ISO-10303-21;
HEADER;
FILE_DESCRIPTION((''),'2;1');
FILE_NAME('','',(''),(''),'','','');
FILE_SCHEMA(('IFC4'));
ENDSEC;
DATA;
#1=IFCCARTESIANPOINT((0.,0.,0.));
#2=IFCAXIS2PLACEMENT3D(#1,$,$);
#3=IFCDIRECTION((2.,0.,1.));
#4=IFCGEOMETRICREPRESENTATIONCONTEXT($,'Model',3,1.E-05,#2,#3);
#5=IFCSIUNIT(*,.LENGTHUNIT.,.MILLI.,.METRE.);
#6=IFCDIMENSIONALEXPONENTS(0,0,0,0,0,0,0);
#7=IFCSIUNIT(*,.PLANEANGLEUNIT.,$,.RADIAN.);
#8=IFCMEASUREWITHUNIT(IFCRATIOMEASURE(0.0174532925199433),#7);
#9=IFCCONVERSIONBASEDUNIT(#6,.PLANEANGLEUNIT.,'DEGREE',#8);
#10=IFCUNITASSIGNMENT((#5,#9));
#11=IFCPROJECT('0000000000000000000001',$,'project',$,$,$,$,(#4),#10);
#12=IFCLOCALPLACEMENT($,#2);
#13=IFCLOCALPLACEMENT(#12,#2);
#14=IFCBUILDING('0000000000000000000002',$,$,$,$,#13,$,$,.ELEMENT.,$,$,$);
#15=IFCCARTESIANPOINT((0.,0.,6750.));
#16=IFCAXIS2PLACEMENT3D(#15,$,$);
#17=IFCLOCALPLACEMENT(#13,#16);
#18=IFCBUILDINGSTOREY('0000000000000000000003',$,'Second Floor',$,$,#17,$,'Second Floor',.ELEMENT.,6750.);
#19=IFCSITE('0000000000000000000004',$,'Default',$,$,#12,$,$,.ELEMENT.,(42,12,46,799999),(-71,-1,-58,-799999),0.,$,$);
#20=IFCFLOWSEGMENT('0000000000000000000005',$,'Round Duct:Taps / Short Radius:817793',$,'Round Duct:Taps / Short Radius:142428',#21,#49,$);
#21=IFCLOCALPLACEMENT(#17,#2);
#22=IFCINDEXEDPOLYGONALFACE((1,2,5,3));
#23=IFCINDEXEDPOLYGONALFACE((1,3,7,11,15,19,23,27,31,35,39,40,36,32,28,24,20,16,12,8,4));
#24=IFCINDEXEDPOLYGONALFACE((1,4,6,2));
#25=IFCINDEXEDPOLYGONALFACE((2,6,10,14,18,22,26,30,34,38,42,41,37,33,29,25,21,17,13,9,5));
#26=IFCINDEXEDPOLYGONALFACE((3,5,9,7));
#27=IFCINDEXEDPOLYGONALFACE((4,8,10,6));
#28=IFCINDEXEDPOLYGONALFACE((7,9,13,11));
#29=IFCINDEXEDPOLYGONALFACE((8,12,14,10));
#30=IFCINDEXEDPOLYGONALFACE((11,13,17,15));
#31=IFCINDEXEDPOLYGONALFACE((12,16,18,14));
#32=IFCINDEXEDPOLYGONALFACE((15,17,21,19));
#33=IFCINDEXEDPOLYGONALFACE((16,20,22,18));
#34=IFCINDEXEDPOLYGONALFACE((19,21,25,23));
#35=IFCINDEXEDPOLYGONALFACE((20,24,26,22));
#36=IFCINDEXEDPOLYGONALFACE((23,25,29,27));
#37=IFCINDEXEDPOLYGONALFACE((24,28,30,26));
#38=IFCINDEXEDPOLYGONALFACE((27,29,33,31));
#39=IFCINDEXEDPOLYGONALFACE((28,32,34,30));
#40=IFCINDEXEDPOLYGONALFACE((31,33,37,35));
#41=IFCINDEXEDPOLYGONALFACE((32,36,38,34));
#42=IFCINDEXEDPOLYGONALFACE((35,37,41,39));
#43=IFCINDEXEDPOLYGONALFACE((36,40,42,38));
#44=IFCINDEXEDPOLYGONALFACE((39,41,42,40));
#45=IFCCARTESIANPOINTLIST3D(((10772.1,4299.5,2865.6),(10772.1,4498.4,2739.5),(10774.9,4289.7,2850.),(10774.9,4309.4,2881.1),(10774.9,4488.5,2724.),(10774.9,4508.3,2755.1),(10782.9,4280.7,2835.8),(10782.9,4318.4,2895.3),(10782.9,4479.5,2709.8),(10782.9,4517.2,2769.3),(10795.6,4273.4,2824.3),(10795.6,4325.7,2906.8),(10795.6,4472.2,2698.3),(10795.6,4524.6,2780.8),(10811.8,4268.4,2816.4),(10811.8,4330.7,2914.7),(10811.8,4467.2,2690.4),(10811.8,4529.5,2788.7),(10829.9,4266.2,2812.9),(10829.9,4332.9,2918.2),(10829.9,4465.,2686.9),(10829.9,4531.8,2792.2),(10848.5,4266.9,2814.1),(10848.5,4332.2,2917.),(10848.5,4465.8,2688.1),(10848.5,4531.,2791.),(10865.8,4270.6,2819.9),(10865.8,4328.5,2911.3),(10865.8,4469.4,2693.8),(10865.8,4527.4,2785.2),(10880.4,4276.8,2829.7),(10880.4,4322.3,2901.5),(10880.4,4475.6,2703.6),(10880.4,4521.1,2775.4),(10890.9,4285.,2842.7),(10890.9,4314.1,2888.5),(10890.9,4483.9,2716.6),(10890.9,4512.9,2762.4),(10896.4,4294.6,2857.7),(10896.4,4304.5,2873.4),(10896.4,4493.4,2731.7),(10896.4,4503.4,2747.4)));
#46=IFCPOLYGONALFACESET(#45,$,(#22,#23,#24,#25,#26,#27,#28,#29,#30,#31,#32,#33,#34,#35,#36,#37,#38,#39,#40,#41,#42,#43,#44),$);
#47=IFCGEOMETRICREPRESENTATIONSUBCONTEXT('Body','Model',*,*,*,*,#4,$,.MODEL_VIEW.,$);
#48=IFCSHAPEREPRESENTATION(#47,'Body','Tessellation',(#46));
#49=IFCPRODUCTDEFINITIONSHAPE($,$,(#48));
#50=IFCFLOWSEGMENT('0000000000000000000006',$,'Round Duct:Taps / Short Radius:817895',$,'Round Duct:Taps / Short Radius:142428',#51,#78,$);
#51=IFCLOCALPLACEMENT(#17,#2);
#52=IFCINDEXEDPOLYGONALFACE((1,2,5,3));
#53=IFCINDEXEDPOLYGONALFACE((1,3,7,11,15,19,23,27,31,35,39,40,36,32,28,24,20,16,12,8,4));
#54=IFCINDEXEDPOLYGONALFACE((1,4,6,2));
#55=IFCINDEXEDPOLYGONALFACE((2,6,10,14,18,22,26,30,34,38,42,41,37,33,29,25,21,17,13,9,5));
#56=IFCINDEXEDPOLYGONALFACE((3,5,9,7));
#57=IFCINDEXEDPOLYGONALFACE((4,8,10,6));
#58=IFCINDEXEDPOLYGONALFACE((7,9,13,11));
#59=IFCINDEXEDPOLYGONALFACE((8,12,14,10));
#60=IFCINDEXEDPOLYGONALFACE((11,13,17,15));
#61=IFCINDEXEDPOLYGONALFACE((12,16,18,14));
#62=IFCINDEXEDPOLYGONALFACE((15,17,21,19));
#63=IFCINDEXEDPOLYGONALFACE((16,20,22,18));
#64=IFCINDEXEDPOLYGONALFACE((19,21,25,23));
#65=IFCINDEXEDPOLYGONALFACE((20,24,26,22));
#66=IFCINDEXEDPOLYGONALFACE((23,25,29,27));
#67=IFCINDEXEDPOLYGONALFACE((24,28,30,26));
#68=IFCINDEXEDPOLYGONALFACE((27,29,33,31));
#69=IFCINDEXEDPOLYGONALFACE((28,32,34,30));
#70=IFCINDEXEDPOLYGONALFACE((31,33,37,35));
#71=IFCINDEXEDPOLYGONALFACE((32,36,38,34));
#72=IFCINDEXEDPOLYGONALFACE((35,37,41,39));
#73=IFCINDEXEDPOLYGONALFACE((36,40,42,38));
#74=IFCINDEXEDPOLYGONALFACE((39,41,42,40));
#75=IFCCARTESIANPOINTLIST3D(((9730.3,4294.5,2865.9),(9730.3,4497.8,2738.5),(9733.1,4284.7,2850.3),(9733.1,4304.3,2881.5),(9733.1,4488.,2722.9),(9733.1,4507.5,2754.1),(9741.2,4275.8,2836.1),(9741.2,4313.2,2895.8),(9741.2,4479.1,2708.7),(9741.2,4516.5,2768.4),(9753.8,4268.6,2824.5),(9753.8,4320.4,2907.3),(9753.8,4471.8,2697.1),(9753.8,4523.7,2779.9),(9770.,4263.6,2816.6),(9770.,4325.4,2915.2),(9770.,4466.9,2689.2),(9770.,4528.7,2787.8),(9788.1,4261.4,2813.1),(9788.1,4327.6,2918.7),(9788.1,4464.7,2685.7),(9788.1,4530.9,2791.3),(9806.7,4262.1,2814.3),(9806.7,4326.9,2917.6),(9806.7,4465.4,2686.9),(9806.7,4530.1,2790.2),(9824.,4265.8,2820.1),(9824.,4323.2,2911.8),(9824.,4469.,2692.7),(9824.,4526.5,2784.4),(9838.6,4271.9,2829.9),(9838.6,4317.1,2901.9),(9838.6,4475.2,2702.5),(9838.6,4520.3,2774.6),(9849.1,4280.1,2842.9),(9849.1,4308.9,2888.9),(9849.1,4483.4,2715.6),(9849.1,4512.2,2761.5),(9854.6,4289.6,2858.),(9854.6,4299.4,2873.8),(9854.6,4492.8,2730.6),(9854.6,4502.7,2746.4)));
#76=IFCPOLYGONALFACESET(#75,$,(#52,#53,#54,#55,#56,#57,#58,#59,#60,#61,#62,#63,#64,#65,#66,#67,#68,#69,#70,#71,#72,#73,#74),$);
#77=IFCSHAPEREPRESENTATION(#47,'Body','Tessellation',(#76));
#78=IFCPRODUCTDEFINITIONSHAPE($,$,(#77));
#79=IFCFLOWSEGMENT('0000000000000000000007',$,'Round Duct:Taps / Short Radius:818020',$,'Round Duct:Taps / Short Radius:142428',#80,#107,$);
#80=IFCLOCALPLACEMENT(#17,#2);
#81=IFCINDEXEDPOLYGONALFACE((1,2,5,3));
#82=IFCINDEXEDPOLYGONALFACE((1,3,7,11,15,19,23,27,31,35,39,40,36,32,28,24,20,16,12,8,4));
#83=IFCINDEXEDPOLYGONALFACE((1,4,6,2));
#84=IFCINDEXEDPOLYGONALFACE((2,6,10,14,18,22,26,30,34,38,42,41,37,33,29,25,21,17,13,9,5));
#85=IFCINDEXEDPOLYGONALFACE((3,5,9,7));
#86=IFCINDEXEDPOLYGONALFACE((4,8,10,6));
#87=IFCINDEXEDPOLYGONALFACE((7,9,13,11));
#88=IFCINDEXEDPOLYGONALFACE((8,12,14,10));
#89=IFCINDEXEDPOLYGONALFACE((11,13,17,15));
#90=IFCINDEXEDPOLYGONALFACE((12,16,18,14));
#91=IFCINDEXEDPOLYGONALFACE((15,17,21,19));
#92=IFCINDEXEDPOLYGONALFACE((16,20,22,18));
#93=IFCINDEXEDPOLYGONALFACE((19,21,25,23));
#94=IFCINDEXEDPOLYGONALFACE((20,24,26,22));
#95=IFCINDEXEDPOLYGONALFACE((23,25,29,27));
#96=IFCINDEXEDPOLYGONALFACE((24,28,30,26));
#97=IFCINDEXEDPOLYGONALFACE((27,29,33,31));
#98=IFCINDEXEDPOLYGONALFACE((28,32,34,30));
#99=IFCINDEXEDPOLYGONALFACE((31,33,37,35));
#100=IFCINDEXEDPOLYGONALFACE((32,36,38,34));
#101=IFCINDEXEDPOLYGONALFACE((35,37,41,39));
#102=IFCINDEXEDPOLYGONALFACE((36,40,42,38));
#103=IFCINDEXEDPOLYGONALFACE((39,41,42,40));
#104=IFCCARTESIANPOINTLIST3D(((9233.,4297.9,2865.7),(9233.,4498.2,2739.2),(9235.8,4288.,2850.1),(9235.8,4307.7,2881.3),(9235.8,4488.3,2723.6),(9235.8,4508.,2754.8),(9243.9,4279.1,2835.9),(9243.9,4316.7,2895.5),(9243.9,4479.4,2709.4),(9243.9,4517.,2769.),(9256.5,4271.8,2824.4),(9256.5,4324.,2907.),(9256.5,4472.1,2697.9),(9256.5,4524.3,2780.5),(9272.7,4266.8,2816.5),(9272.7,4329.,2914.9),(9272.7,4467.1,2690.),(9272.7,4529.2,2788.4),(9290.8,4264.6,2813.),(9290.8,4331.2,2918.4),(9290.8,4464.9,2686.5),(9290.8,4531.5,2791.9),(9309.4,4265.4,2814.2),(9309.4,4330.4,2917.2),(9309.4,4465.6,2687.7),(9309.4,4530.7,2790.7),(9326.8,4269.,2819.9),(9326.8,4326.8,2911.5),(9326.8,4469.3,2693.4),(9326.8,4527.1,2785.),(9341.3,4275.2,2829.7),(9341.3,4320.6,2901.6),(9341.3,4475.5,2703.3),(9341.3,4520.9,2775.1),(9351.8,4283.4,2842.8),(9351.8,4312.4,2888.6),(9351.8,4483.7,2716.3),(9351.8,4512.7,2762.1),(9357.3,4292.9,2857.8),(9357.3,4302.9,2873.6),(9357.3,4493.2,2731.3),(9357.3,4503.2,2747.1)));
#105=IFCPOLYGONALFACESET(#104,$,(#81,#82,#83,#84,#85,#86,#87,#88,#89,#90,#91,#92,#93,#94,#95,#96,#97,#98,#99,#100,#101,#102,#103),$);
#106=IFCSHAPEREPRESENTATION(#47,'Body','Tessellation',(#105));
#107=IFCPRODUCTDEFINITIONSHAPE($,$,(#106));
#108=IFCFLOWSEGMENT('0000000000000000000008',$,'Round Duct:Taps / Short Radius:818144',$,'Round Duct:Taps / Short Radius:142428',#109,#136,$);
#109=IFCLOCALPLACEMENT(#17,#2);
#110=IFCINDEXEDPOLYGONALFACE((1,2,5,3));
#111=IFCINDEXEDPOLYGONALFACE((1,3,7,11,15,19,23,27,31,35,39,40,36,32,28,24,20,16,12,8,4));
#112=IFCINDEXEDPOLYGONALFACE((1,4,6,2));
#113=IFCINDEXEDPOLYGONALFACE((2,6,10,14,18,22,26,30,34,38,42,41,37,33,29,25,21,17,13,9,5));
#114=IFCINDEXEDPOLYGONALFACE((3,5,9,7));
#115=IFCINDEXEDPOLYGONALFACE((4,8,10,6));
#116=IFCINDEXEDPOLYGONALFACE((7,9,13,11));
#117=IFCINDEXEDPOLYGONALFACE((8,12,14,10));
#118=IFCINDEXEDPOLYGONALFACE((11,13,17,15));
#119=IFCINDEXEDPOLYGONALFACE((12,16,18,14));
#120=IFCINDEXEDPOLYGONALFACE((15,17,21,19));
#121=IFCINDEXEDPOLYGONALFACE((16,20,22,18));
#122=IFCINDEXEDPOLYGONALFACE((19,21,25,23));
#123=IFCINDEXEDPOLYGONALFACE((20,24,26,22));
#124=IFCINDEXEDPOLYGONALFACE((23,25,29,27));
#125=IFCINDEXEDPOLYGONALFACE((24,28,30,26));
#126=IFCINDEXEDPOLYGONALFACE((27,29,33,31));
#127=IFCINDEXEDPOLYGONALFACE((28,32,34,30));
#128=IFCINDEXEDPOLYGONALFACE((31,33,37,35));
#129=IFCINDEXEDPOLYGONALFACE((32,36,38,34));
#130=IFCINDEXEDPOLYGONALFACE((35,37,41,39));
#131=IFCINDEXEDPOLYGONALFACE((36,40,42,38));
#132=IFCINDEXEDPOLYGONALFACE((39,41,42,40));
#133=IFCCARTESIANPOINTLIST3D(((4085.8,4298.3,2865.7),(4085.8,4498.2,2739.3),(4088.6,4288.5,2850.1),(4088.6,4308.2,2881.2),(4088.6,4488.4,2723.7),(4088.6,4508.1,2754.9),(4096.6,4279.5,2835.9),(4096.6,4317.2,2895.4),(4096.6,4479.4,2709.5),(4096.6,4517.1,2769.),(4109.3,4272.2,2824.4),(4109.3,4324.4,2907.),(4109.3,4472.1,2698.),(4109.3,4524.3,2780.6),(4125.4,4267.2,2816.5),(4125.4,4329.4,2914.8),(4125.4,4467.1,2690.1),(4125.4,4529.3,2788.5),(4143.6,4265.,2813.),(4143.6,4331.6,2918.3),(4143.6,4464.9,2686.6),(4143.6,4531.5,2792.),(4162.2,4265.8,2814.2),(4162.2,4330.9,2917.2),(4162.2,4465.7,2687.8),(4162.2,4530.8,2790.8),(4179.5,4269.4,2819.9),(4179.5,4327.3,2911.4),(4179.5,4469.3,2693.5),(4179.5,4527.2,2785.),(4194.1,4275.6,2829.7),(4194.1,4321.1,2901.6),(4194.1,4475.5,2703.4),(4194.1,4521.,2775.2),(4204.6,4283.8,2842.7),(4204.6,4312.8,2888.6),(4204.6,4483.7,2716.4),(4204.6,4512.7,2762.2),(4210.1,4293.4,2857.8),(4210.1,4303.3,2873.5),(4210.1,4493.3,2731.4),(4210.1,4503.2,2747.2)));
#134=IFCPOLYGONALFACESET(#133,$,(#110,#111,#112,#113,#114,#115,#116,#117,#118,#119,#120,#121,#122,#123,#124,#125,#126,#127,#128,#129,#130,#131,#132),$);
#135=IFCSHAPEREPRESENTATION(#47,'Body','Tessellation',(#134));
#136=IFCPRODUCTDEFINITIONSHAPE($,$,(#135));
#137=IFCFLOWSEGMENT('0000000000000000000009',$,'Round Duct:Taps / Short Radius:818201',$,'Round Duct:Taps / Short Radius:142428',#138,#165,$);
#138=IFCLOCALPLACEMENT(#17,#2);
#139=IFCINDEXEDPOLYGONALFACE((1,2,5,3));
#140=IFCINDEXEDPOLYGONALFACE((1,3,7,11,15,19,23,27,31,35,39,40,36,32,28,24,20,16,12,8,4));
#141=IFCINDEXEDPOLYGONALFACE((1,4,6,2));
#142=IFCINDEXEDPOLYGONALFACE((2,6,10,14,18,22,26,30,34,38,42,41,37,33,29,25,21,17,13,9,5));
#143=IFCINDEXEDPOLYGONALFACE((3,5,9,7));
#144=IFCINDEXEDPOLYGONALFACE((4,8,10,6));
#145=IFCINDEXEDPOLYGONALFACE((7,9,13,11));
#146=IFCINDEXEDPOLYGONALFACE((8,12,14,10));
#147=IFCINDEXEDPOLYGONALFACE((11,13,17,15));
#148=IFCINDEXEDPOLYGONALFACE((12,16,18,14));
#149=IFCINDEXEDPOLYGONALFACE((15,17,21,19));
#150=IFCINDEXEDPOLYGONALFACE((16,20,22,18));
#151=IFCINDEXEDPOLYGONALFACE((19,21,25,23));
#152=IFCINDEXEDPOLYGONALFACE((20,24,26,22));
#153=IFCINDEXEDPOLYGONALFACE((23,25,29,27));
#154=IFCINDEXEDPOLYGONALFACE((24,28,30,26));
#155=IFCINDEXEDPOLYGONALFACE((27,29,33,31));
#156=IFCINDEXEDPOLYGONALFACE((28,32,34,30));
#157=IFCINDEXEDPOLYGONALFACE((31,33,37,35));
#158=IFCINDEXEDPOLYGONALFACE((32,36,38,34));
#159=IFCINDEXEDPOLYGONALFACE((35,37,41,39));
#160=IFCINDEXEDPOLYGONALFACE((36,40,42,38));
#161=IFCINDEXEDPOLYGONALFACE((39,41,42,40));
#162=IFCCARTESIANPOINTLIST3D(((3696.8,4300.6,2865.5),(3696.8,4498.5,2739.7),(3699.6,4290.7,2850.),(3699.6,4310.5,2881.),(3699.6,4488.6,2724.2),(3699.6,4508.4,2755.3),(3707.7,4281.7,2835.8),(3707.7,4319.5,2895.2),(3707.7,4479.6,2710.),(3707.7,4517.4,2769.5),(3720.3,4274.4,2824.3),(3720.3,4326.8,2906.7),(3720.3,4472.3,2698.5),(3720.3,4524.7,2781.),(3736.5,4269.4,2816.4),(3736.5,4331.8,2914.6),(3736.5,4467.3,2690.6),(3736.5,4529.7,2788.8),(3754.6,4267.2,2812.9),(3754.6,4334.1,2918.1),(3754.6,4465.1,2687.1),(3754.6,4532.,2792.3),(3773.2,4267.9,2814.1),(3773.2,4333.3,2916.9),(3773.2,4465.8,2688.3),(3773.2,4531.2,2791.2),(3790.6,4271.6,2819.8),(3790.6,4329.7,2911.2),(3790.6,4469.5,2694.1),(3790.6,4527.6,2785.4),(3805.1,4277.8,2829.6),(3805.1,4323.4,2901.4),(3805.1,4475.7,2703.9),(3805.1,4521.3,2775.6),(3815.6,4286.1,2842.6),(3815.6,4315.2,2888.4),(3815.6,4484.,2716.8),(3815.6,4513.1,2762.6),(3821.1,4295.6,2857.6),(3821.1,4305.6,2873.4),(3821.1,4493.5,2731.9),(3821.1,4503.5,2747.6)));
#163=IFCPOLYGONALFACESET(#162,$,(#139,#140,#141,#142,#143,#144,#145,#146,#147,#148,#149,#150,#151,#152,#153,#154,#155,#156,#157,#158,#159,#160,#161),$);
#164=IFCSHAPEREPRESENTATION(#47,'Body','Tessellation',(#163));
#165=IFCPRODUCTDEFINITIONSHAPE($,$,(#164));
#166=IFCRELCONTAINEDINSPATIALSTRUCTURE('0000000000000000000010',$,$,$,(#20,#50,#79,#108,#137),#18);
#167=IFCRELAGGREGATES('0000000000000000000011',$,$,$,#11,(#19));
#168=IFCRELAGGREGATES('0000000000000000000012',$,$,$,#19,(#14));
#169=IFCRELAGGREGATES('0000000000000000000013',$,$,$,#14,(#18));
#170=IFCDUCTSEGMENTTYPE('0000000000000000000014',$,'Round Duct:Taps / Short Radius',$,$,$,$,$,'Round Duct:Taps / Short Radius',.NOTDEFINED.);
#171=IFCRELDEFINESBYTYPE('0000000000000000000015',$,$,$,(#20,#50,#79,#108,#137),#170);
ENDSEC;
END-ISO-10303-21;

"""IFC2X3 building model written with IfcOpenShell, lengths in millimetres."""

from ifc_helpers import new_model, entity, si_unit, converted_unit, direction, frame, frame_2d, origin, place, context, subcontext, project, spatial, circle, extrude, type_object, element, save


model = new_model("IFC2X3")

# Units and contexts
model_context = context("Model", 3, precision=1e-05, world=origin(), true_north=direction((2.0, 0.0, 1.0)))
body_context = subcontext(model_context, "Body", "Model", "MODEL_VIEW")
ifc_project = project(units=[si_unit("LENGTHUNIT", "METRE", prefix="MILLI"), converted_unit("PLANEANGLEUNIT", "DEGREE", entity("IfcRatioMeasure", 0.0174532925199433), si_unit("PLANEANGLEUNIT", "RADIAN"), dimensions=[0, 0, 0, 0, 0, 0, 0])], contexts=[model_context])

# Site, building, storey
site_placement = place(None, origin())
site = spatial("IfcSite", under=ifc_project, at=site_placement, Name="Default", CompositionType="ELEMENT", RefLatitude=(42, 12, 46, 799999), RefLongitude=(-71, -1, -58, -799999), RefElevation=0.0)
building_placement = place(site_placement, origin())
building = spatial("IfcBuilding", under=site, at=building_placement, CompositionType="ELEMENT")
storey_placement = place(building_placement, frame((0.0, 0.0, 6750.0)))
storey = spatial("IfcBuildingStorey", under=building, at=storey_placement, Name="Second Floor", LongName="Second Floor", CompositionType="ELEMENT", Elevation=6750.0)

# Flow segments
duct_segment_type = type_object("IfcDuctSegmentType", Name="Round Duct:Taps / Short Radius", ElementType="Round Duct:Taps / Short Radius", PredefinedType="NOTDEFINED")
flow_segment_1_placement = place(storey_placement, origin())
element("IfcFlowSegment", 1, at=flow_segment_1_placement, inside=storey, type_object=duct_segment_type, Name="Round Duct:Taps / Short Radius:817793", ObjectType="Round Duct:Taps / Short Radius:142428", context=body_context, shape_type="SweptSolid", body=[
    extrude(circle(Radius=62.5, at=frame_2d((0.0, 0.0), x_axis=(1.0, 0.0))), frame((10834.6, 4299.5, 2865.6), z_axis=(0.0, 0.844594, -0.535407), x_axis=(-1.0, 0.0, 0.0)), (0.0, 0.0, 1.0), 235.4),
])
flow_segment_2_placement = place(storey_placement, origin())
element("IfcFlowSegment", 2, at=flow_segment_2_placement, inside=storey, type_object=duct_segment_type, Name="Round Duct:Taps / Short Radius:817895", ObjectType="Round Duct:Taps / Short Radius:142428", context=body_context, shape_type="SweptSolid", body=[
    extrude(circle(Radius=62.5, at=frame_2d((0.0, 0.0), x_axis=(1.0, 0.0))), frame((9792.8, 4497.8, 2738.5), z_axis=(0.0, -0.847349, 0.531037), x_axis=(-1.0, 0.0, 0.0)), (0.0, 0.0, 1.0), 239.9),
])
flow_segment_3_placement = place(storey_placement, origin())
element("IfcFlowSegment", 3, at=flow_segment_3_placement, inside=storey, type_object=duct_segment_type, Name="Round Duct:Taps / Short Radius:818020", ObjectType="Round Duct:Taps / Short Radius:142428", context=body_context, shape_type="SweptSolid", body=[
    extrude(circle(Radius=62.5, at=frame_2d((0.0, 0.0), x_axis=(1.0, 0.0))), frame((9295.5, 4297.9, 2865.7), z_axis=(0.0, 0.845507, -0.533964), x_axis=(-1.0, 0.0, 0.0)), (0.0, 0.0, 1.0), 236.9),
])
flow_segment_4_placement = place(storey_placement, origin())
element("IfcFlowSegment", 4, at=flow_segment_4_placement, inside=storey, type_object=duct_segment_type, Name="Round Duct:Taps / Short Radius:818144", ObjectType="Round Duct:Taps / Short Radius:142428", context=body_context, shape_type="SweptSolid", body=[
    extrude(circle(Radius=62.5, at=frame_2d((0.0, 0.0), x_axis=(1.0, 0.0))), frame((4148.3, 4498.2, 2739.3), z_axis=(0.0, -0.84526, 0.534356), x_axis=(-1.0, 0.0, 0.0)), (0.0, 0.0, 1.0), 236.5),
])
flow_segment_5_placement = place(storey_placement, origin())
element("IfcFlowSegment", 5, at=flow_segment_5_placement, inside=storey, type_object=duct_segment_type, Name="Round Duct:Taps / Short Radius:818201", ObjectType="Round Duct:Taps / Short Radius:142428", context=body_context, shape_type="SweptSolid", body=[
    extrude(circle(Radius=62.5, at=frame_2d((0.0, 0.0), x_axis=(1.0, 0.0))), frame((3759.3, 4498.5, 2739.7), z_axis=(0.0, -0.843996, 0.53635), x_axis=(-1.0, 0.0, 0.0)), (0.0, 0.0, 1.0), 234.5),
])

save(model, "model.ifc")
